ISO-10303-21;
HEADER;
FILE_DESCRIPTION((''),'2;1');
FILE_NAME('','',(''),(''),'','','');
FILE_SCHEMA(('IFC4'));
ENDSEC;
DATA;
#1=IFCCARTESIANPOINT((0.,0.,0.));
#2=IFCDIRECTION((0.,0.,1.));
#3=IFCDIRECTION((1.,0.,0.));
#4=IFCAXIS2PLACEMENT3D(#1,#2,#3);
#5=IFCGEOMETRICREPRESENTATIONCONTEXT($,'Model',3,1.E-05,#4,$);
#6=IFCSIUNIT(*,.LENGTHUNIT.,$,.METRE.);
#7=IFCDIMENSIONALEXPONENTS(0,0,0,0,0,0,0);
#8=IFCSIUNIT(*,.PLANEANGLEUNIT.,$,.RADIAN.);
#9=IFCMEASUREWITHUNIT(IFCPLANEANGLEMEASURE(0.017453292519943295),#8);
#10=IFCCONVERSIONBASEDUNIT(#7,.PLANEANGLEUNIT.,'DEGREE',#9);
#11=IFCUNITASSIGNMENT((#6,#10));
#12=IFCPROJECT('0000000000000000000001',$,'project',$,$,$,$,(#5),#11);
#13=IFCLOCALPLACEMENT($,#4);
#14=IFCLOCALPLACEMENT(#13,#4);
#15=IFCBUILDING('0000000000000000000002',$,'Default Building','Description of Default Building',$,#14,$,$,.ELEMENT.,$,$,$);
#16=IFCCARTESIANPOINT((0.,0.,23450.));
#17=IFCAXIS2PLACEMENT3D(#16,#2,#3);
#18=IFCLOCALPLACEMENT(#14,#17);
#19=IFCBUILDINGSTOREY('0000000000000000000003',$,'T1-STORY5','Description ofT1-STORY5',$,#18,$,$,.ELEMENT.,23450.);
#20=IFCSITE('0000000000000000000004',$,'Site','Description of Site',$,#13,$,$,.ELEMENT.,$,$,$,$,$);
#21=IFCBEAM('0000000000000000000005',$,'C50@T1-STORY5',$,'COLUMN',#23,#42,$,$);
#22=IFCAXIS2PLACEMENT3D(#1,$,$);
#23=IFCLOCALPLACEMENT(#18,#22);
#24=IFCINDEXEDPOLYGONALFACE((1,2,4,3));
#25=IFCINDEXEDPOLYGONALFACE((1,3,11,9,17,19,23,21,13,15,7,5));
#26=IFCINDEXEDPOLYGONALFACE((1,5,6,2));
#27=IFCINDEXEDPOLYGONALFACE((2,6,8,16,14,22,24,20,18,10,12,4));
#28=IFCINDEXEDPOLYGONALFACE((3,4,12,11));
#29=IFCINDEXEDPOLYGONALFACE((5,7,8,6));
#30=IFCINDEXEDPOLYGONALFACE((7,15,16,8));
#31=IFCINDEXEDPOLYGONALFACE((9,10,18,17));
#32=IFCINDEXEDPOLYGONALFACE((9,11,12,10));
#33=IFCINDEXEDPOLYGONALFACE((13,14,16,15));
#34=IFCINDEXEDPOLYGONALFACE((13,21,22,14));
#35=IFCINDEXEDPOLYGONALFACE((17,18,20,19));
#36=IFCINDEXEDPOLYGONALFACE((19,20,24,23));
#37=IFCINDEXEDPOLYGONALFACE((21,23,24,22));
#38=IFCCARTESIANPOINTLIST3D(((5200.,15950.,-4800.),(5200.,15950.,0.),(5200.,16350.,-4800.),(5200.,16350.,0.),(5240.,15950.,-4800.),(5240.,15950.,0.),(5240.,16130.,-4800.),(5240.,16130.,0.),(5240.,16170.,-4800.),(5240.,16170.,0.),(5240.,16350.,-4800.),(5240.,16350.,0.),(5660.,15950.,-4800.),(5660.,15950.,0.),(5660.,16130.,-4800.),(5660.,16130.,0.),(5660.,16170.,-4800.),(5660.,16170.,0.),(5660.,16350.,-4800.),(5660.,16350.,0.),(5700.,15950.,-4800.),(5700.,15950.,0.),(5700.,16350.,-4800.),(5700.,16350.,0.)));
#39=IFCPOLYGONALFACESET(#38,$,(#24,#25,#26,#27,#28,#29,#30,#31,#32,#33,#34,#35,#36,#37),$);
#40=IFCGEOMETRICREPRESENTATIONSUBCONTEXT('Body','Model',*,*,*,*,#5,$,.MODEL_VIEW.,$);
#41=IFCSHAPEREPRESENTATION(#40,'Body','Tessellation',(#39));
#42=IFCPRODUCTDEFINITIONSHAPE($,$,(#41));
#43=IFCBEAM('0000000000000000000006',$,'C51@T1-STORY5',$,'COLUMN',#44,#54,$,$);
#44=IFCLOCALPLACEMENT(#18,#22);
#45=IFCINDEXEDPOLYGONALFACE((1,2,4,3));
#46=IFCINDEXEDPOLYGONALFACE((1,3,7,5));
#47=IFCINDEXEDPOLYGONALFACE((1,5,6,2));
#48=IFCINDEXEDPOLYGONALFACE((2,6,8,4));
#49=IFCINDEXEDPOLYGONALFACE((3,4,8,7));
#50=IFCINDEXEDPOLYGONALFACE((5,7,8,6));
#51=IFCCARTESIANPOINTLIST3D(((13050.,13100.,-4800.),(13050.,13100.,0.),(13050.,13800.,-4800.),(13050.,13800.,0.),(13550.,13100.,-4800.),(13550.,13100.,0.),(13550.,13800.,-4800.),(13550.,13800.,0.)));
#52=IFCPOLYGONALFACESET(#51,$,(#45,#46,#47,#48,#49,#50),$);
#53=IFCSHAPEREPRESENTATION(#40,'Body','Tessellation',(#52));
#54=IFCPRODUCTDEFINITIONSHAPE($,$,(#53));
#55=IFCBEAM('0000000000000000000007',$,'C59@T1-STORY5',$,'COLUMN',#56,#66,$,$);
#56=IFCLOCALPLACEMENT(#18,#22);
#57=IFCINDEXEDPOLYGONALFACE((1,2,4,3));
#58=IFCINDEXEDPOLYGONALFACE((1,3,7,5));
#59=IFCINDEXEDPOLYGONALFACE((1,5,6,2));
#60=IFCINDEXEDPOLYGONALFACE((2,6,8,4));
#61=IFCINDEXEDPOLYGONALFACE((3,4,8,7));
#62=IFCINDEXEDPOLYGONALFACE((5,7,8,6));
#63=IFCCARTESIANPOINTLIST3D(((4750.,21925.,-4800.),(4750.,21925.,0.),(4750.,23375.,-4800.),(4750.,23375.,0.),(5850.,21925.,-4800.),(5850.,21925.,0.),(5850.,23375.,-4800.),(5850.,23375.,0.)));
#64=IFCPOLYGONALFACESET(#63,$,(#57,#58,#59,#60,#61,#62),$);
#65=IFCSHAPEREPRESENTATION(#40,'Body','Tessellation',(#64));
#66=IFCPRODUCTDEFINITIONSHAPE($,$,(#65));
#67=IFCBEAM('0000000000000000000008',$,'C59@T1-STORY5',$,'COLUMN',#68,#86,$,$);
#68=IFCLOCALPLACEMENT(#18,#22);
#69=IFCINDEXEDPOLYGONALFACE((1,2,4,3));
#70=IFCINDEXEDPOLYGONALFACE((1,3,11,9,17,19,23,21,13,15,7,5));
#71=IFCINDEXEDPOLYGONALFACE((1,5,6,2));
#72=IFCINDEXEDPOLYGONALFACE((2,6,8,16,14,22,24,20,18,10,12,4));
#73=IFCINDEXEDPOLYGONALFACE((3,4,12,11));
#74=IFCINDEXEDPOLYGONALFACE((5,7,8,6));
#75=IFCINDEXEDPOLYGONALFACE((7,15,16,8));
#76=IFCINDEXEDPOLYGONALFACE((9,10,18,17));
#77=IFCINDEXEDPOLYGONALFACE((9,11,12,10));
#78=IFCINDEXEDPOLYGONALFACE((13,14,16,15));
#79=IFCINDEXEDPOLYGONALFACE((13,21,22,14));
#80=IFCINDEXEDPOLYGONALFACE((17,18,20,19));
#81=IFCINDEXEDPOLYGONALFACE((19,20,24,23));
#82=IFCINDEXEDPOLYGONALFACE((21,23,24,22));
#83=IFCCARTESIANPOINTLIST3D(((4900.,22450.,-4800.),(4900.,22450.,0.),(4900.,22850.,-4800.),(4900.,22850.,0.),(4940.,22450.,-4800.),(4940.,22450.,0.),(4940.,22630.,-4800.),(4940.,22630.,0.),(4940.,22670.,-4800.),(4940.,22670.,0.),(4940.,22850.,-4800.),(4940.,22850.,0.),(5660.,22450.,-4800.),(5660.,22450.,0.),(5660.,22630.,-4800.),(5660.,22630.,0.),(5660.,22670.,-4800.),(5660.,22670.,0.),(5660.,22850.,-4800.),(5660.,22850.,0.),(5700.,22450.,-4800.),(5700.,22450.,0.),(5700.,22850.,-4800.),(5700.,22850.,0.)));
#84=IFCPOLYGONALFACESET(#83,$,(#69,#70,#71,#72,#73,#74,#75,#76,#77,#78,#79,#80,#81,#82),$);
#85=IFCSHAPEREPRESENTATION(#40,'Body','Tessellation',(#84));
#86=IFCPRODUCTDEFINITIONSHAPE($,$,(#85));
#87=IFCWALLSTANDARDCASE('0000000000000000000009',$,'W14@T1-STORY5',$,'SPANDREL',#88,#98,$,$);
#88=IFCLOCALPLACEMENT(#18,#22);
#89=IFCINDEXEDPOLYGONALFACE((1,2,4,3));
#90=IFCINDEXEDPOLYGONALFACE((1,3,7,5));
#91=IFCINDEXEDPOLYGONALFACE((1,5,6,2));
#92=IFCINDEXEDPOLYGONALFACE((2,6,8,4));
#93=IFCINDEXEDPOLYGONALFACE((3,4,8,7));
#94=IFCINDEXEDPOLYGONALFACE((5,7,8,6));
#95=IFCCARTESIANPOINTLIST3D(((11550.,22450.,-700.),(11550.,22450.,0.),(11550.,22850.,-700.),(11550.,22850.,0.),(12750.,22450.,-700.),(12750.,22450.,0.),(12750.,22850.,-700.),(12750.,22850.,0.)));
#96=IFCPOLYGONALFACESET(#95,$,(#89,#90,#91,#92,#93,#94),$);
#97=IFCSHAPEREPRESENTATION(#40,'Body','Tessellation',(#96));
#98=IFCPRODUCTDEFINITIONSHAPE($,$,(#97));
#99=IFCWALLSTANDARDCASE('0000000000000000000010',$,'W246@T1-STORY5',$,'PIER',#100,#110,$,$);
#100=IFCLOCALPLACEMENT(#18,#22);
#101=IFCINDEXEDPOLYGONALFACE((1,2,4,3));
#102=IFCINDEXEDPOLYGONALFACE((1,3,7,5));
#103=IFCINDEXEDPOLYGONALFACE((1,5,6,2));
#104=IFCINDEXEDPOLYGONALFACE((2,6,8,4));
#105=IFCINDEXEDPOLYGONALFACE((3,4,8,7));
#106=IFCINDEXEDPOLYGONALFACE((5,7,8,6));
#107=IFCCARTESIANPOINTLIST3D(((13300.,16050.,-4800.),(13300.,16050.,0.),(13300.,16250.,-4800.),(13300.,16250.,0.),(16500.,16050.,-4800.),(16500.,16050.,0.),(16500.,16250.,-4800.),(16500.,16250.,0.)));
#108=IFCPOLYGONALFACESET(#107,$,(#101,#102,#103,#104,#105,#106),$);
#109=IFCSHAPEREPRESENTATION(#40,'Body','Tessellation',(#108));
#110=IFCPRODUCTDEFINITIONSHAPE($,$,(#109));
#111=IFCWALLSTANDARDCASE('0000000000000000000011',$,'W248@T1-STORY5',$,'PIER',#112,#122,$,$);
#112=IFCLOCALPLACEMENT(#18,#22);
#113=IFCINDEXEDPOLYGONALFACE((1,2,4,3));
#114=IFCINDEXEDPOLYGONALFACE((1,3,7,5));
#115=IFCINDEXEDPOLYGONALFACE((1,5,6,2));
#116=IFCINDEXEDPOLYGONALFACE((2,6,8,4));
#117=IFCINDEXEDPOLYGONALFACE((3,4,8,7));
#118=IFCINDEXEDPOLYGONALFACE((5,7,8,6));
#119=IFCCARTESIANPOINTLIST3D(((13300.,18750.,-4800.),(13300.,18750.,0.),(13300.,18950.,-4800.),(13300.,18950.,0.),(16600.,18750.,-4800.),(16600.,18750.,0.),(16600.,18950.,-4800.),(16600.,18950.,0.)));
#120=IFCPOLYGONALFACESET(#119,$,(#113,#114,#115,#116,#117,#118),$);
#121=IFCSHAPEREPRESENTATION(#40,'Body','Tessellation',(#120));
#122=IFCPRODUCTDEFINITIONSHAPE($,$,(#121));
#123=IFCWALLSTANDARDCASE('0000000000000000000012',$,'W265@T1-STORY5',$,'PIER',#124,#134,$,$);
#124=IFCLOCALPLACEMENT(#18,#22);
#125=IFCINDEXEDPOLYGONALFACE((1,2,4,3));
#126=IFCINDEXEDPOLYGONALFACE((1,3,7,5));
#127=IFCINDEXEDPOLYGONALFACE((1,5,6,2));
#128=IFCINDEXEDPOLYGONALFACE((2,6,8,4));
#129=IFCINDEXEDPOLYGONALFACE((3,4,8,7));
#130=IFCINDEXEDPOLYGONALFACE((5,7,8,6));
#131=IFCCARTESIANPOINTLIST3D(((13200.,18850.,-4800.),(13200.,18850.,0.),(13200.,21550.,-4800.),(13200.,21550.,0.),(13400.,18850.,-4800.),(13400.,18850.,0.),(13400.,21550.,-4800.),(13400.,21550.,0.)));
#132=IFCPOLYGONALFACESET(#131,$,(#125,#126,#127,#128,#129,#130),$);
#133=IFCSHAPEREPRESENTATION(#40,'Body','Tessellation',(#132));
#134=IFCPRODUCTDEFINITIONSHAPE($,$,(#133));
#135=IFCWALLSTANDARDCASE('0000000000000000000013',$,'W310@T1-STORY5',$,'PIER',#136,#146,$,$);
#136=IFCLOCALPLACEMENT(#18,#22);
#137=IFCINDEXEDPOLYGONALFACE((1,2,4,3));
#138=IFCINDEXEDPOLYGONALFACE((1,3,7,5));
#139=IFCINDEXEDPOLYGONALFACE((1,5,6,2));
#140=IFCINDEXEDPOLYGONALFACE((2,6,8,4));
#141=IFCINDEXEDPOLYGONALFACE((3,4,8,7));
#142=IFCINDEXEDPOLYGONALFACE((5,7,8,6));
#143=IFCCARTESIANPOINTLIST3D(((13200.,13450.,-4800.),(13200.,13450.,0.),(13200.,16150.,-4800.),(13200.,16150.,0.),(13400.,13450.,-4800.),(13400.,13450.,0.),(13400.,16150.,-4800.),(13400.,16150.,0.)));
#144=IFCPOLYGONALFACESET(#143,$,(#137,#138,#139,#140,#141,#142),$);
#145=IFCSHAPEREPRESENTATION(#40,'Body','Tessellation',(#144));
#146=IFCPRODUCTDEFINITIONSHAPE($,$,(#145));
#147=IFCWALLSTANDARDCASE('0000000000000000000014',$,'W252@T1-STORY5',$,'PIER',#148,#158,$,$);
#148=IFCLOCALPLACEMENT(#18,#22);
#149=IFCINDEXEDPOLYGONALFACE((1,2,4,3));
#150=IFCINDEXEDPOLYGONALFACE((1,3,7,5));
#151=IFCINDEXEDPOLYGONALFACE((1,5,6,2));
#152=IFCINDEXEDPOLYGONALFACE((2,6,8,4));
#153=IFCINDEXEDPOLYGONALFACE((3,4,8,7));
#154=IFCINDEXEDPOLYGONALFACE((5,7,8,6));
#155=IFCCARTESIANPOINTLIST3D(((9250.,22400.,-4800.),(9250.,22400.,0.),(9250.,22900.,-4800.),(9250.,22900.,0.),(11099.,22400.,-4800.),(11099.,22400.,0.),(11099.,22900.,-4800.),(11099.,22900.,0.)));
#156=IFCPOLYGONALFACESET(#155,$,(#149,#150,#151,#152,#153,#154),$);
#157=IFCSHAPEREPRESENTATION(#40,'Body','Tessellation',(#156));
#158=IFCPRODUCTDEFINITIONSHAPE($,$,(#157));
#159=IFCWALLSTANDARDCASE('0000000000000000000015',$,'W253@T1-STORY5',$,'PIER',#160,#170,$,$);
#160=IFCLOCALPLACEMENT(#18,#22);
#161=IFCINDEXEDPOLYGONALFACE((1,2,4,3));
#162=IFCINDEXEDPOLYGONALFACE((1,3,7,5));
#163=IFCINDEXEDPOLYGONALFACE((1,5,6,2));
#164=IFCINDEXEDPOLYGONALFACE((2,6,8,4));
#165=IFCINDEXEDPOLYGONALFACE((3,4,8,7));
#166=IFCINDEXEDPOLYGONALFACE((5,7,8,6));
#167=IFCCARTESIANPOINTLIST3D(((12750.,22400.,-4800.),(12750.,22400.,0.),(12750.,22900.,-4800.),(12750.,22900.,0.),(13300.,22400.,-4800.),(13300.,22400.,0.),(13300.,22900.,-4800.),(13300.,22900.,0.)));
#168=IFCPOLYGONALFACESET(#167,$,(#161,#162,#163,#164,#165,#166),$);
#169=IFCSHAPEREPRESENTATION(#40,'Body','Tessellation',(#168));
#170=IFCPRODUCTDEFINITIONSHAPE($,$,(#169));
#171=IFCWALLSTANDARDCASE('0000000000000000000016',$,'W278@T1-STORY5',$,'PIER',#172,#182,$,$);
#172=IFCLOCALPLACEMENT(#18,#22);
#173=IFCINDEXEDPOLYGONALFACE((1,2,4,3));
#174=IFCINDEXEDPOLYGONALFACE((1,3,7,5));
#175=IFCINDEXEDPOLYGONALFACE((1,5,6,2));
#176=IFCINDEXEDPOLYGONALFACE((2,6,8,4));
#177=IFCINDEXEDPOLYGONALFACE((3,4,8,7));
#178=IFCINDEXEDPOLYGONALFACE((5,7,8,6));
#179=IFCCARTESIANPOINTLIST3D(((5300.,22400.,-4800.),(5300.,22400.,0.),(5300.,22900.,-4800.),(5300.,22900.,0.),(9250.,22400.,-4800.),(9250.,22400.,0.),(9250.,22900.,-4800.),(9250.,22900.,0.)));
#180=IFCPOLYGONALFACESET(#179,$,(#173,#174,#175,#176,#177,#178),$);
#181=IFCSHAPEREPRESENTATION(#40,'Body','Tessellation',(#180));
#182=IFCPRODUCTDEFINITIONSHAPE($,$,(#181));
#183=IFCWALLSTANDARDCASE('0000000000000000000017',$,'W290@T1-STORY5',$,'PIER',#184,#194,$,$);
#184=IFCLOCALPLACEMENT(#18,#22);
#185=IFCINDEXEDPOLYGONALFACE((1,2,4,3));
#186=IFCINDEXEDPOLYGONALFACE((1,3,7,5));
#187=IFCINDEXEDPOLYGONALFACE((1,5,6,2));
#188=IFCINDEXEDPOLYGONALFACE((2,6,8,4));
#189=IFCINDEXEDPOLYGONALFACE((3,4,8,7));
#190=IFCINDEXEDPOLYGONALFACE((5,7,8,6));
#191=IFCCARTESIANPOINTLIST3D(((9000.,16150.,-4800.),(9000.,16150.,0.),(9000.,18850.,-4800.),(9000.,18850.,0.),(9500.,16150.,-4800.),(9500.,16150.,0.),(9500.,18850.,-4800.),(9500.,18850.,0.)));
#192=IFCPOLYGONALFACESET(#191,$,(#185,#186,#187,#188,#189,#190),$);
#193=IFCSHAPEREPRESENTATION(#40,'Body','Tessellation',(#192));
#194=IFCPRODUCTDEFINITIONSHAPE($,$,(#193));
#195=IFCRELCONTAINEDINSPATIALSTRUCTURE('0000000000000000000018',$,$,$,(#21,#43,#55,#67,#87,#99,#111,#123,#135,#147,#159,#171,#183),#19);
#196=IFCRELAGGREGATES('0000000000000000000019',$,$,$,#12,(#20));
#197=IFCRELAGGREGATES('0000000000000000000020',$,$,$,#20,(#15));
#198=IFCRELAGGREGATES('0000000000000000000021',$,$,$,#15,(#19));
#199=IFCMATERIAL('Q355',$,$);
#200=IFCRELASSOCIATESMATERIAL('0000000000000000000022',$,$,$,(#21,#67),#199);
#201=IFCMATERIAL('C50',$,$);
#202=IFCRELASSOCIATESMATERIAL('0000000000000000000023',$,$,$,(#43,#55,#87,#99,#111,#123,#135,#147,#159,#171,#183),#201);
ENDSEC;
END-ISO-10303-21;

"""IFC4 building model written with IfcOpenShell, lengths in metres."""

from ifc_helpers import new_model, entity, si_unit, converted_unit, frame, origin_with_axes, place, context, subcontext, project, spatial, indexed_curve, rectangle, i_section, outline, extrude, material, element, save


model = new_model("IFC4")

# Units and contexts
model_context = context("Model", 3, precision=1e-05, world=origin_with_axes())
body_context = subcontext(model_context, "Body", "Model", "MODEL_VIEW")
ifc_project = project(units=[si_unit("LENGTHUNIT", "METRE"), converted_unit("PLANEANGLEUNIT", "DEGREE", entity("IfcPlaneAngleMeasure", 0.017453292519943295), si_unit("PLANEANGLEUNIT", "RADIAN"), dimensions=[0, 0, 0, 0, 0, 0, 0])], contexts=[model_context])

# Site, building, storey
site_placement = place(None, origin_with_axes())
site = spatial("IfcSite", under=ifc_project, at=site_placement, Name="Site", Description="Description of Site", CompositionType="ELEMENT")
building_placement = place(site_placement, origin_with_axes())
building = spatial("IfcBuilding", under=site, at=building_placement, Name="Default Building", Description="Description of Default Building", CompositionType="ELEMENT")
storey_placement = place(building_placement, frame((0.0, 0.0, 23450.0), z_axis=(0.0, 0.0, 1.0), x_axis=(1.0, 0.0, 0.0)))
storey = spatial("IfcBuildingStorey", under=building, at=storey_placement, Name="T1-STORY5", Description="Description ofT1-STORY5", CompositionType="ELEMENT", Elevation=23450.0)

# Beams
ifc_material_1 = material(Name="C50")
ifc_material_2 = material(Name="Q355")
beam_1_placement = place(storey_placement, frame((5450.0, 16150.0, -4800.0), z_axis=(0.0, 0.0, 1.0), x_axis=(0.0, -1.0, 0.0)))
element("IfcBeam", 1, at=beam_1_placement, inside=storey, material=ifc_material_2, Name="C50@T1-STORY5", ObjectType="COLUMN", context=body_context, shape_type="SweptSolid", body=[
    extrude(i_section(OverallWidth=400.0, OverallDepth=500.0, WebThickness=40.0, FlangeThickness=40.0, FilletRadius=0.0), origin_with_axes(), (0.0, 0.0, 1.0), 4800.0),
])
beam_2_placement = place(storey_placement, frame((13300.0, 13450.0, -4800.0), z_axis=(0.0, 0.0, 1.0), x_axis=(-1.0, 0.0, 0.0)))
element("IfcBeam", 2, at=beam_2_placement, inside=storey, material=ifc_material_1, Name="C51@T1-STORY5", ObjectType="COLUMN", context=body_context, shape_type="SweptSolid", body=[
    extrude(rectangle(XDim=500.0, YDim=700.0), origin_with_axes(), (0.0, 0.0, 1.0), 4800.0),
])
beam_3_placement = place(storey_placement, frame((5300.0, 22650.0, -4800.0), z_axis=(0.0, 0.0, 1.0), x_axis=(0.0, -1.0, 0.0)))
element("IfcBeam", 3, at=beam_3_placement, inside=storey, material=ifc_material_1, Name="C59@T1-STORY5", ObjectType="COLUMN", context=body_context, shape_type="SweptSolid", body=[
    extrude(rectangle(XDim=1450.0, YDim=1100.0), origin_with_axes(), (0.0, 0.0, 1.0), 4800.0),
])
beam_4_placement = place(storey_placement, frame((5300.0, 22650.0, -4800.0), z_axis=(0.0, 0.0, 1.0), x_axis=(0.0, -1.0, 0.0)))
element("IfcBeam", 4, at=beam_4_placement, inside=storey, material=ifc_material_2, Name="C59@T1-STORY5", ObjectType="COLUMN", context=body_context, shape_type="SweptSolid", body=[
    extrude(i_section(OverallWidth=400.0, OverallDepth=800.0, WebThickness=40.0, FlangeThickness=40.0, FilletRadius=0.0), origin_with_axes(), (0.0, 0.0, 1.0), 4800.0),
])

# Walls
wall_1_placement = place(storey_placement, frame((11550.0, 22650.0, -700.0), z_axis=(0.0, 0.0, 1.0), x_axis=(1.0, 0.0, 0.0)))
element("IfcWallStandardCase", 5, at=wall_1_placement, inside=storey, material=ifc_material_1, Name="W14@T1-STORY5", ObjectType="SPANDREL", context=body_context, shape_type="SweptSolid", body=[
    extrude(outline(indexed_curve([(0.0, -200.0), (0.0, 200.0), (1200.0, 200.0), (1200.0, -200.0), (0.0, -200.0)], self_intersect=False)), origin_with_axes(), (0.0, 0.0, 1.0), 700.0),
])
wall_2_placement = place(storey_placement, frame((13300.0, 16150.0, -4800.0), z_axis=(0.0, 0.0, 1.0), x_axis=(1.0, 0.0, 0.0)))
element("IfcWallStandardCase", 6, at=wall_2_placement, inside=storey, material=ifc_material_1, Name="W246@T1-STORY5", ObjectType="PIER", context=body_context, shape_type="SweptSolid", body=[
    extrude(outline(indexed_curve([(0.0, -100.0), (0.0, 100.0), (3200.0, 100.0), (3200.0, -100.0), (0.0, -100.0)], self_intersect=False)), origin_with_axes(), (0.0, 0.0, 1.0), 4800.0),
])
wall_3_placement = place(storey_placement, frame((13300.0, 18850.0, -4800.0), z_axis=(0.0, 0.0, 1.0), x_axis=(1.0, 0.0, 0.0)))
element("IfcWallStandardCase", 7, at=wall_3_placement, inside=storey, material=ifc_material_1, Name="W248@T1-STORY5", ObjectType="PIER", context=body_context, shape_type="SweptSolid", body=[
    extrude(outline(indexed_curve([(0.0, -100.0), (0.0, 100.0), (3300.0, 100.0), (3300.0, -100.0), (0.0, -100.0)], self_intersect=False)), origin_with_axes(), (0.0, 0.0, 1.0), 4800.0),
])
for number, where, z_axis, x_axis, name in (
    (8, (13300.0, 18850.0, -4800.0), (0.0, 0.0, 1.0), (0.0, 1.0, 0.0), "W265@T1-STORY5"),
    (9, (13300.0, 13450.0, -4800.0), (0.0, 0.0, 1.0), (0.0, 1.0, 0.0), "W310@T1-STORY5"),
):
    element("IfcWallStandardCase", number, at=place(storey_placement, frame(where, z_axis=z_axis, x_axis=x_axis)), inside=storey, material=ifc_material_1, Name=name, ObjectType="PIER", context=body_context, shape_type="SweptSolid", body=[
        extrude(outline(indexed_curve([(0.0, -100.0), (0.0, 100.0), (2700.0, 100.0), (2700.0, -100.0), (0.0, -100.0)], self_intersect=False)), origin_with_axes(), (0.0, 0.0, 1.0), 4800.0),
    ])
wall_4_placement = place(storey_placement, frame((9250.0, 22650.0, -4800.0), z_axis=(0.0, 0.0, 1.0), x_axis=(1.0, 0.0, 0.0)))
element("IfcWallStandardCase", 10, at=wall_4_placement, inside=storey, material=ifc_material_1, Name="W252@T1-STORY5", ObjectType="PIER", context=body_context, shape_type="SweptSolid", body=[
    extrude(outline(indexed_curve([(0.0, -250.0), (0.0, 250.0), (1849.0, 250.0), (1849.0, -250.0), (0.0, -250.0)], self_intersect=False)), origin_with_axes(), (0.0, 0.0, 1.0), 4800.0),
])
wall_5_placement = place(storey_placement, frame((12750.0, 22650.0, -4800.0), z_axis=(0.0, 0.0, 1.0), x_axis=(1.0, 0.0, 0.0)))
element("IfcWallStandardCase", 11, at=wall_5_placement, inside=storey, material=ifc_material_1, Name="W253@T1-STORY5", ObjectType="PIER", context=body_context, shape_type="SweptSolid", body=[
    extrude(outline(indexed_curve([(0.0, -250.0), (0.0, 250.0), (550.0, 250.0), (550.0, -250.0), (0.0, -250.0)], self_intersect=False)), origin_with_axes(), (0.0, 0.0, 1.0), 4800.0),
])
wall_6_placement = place(storey_placement, frame((5300.0, 22650.0, -4800.0), z_axis=(0.0, 0.0, 1.0), x_axis=(1.0, 0.0, 0.0)))
element("IfcWallStandardCase", 12, at=wall_6_placement, inside=storey, material=ifc_material_1, Name="W278@T1-STORY5", ObjectType="PIER", context=body_context, shape_type="SweptSolid", body=[
    extrude(outline(indexed_curve([(0.0, -250.0), (0.0, 250.0), (3950.0, 250.0), (3950.0, -250.0), (0.0, -250.0)], self_intersect=False)), origin_with_axes(), (0.0, 0.0, 1.0), 4800.0),
])
wall_7_placement = place(storey_placement, frame((9250.0, 16150.0, -4800.0), z_axis=(0.0, 0.0, 1.0), x_axis=(0.0, 1.0, 0.0)))
element("IfcWallStandardCase", 13, at=wall_7_placement, inside=storey, material=ifc_material_1, Name="W290@T1-STORY5", ObjectType="PIER", context=body_context, shape_type="SweptSolid", body=[
    extrude(outline(indexed_curve([(0.0, -250.0), (0.0, 250.0), (2700.0, 250.0), (2700.0, -250.0), (0.0, -250.0)], self_intersect=False)), origin_with_axes(), (0.0, 0.0, 1.0), 4800.0),
])

save(model, "model.ifc")
